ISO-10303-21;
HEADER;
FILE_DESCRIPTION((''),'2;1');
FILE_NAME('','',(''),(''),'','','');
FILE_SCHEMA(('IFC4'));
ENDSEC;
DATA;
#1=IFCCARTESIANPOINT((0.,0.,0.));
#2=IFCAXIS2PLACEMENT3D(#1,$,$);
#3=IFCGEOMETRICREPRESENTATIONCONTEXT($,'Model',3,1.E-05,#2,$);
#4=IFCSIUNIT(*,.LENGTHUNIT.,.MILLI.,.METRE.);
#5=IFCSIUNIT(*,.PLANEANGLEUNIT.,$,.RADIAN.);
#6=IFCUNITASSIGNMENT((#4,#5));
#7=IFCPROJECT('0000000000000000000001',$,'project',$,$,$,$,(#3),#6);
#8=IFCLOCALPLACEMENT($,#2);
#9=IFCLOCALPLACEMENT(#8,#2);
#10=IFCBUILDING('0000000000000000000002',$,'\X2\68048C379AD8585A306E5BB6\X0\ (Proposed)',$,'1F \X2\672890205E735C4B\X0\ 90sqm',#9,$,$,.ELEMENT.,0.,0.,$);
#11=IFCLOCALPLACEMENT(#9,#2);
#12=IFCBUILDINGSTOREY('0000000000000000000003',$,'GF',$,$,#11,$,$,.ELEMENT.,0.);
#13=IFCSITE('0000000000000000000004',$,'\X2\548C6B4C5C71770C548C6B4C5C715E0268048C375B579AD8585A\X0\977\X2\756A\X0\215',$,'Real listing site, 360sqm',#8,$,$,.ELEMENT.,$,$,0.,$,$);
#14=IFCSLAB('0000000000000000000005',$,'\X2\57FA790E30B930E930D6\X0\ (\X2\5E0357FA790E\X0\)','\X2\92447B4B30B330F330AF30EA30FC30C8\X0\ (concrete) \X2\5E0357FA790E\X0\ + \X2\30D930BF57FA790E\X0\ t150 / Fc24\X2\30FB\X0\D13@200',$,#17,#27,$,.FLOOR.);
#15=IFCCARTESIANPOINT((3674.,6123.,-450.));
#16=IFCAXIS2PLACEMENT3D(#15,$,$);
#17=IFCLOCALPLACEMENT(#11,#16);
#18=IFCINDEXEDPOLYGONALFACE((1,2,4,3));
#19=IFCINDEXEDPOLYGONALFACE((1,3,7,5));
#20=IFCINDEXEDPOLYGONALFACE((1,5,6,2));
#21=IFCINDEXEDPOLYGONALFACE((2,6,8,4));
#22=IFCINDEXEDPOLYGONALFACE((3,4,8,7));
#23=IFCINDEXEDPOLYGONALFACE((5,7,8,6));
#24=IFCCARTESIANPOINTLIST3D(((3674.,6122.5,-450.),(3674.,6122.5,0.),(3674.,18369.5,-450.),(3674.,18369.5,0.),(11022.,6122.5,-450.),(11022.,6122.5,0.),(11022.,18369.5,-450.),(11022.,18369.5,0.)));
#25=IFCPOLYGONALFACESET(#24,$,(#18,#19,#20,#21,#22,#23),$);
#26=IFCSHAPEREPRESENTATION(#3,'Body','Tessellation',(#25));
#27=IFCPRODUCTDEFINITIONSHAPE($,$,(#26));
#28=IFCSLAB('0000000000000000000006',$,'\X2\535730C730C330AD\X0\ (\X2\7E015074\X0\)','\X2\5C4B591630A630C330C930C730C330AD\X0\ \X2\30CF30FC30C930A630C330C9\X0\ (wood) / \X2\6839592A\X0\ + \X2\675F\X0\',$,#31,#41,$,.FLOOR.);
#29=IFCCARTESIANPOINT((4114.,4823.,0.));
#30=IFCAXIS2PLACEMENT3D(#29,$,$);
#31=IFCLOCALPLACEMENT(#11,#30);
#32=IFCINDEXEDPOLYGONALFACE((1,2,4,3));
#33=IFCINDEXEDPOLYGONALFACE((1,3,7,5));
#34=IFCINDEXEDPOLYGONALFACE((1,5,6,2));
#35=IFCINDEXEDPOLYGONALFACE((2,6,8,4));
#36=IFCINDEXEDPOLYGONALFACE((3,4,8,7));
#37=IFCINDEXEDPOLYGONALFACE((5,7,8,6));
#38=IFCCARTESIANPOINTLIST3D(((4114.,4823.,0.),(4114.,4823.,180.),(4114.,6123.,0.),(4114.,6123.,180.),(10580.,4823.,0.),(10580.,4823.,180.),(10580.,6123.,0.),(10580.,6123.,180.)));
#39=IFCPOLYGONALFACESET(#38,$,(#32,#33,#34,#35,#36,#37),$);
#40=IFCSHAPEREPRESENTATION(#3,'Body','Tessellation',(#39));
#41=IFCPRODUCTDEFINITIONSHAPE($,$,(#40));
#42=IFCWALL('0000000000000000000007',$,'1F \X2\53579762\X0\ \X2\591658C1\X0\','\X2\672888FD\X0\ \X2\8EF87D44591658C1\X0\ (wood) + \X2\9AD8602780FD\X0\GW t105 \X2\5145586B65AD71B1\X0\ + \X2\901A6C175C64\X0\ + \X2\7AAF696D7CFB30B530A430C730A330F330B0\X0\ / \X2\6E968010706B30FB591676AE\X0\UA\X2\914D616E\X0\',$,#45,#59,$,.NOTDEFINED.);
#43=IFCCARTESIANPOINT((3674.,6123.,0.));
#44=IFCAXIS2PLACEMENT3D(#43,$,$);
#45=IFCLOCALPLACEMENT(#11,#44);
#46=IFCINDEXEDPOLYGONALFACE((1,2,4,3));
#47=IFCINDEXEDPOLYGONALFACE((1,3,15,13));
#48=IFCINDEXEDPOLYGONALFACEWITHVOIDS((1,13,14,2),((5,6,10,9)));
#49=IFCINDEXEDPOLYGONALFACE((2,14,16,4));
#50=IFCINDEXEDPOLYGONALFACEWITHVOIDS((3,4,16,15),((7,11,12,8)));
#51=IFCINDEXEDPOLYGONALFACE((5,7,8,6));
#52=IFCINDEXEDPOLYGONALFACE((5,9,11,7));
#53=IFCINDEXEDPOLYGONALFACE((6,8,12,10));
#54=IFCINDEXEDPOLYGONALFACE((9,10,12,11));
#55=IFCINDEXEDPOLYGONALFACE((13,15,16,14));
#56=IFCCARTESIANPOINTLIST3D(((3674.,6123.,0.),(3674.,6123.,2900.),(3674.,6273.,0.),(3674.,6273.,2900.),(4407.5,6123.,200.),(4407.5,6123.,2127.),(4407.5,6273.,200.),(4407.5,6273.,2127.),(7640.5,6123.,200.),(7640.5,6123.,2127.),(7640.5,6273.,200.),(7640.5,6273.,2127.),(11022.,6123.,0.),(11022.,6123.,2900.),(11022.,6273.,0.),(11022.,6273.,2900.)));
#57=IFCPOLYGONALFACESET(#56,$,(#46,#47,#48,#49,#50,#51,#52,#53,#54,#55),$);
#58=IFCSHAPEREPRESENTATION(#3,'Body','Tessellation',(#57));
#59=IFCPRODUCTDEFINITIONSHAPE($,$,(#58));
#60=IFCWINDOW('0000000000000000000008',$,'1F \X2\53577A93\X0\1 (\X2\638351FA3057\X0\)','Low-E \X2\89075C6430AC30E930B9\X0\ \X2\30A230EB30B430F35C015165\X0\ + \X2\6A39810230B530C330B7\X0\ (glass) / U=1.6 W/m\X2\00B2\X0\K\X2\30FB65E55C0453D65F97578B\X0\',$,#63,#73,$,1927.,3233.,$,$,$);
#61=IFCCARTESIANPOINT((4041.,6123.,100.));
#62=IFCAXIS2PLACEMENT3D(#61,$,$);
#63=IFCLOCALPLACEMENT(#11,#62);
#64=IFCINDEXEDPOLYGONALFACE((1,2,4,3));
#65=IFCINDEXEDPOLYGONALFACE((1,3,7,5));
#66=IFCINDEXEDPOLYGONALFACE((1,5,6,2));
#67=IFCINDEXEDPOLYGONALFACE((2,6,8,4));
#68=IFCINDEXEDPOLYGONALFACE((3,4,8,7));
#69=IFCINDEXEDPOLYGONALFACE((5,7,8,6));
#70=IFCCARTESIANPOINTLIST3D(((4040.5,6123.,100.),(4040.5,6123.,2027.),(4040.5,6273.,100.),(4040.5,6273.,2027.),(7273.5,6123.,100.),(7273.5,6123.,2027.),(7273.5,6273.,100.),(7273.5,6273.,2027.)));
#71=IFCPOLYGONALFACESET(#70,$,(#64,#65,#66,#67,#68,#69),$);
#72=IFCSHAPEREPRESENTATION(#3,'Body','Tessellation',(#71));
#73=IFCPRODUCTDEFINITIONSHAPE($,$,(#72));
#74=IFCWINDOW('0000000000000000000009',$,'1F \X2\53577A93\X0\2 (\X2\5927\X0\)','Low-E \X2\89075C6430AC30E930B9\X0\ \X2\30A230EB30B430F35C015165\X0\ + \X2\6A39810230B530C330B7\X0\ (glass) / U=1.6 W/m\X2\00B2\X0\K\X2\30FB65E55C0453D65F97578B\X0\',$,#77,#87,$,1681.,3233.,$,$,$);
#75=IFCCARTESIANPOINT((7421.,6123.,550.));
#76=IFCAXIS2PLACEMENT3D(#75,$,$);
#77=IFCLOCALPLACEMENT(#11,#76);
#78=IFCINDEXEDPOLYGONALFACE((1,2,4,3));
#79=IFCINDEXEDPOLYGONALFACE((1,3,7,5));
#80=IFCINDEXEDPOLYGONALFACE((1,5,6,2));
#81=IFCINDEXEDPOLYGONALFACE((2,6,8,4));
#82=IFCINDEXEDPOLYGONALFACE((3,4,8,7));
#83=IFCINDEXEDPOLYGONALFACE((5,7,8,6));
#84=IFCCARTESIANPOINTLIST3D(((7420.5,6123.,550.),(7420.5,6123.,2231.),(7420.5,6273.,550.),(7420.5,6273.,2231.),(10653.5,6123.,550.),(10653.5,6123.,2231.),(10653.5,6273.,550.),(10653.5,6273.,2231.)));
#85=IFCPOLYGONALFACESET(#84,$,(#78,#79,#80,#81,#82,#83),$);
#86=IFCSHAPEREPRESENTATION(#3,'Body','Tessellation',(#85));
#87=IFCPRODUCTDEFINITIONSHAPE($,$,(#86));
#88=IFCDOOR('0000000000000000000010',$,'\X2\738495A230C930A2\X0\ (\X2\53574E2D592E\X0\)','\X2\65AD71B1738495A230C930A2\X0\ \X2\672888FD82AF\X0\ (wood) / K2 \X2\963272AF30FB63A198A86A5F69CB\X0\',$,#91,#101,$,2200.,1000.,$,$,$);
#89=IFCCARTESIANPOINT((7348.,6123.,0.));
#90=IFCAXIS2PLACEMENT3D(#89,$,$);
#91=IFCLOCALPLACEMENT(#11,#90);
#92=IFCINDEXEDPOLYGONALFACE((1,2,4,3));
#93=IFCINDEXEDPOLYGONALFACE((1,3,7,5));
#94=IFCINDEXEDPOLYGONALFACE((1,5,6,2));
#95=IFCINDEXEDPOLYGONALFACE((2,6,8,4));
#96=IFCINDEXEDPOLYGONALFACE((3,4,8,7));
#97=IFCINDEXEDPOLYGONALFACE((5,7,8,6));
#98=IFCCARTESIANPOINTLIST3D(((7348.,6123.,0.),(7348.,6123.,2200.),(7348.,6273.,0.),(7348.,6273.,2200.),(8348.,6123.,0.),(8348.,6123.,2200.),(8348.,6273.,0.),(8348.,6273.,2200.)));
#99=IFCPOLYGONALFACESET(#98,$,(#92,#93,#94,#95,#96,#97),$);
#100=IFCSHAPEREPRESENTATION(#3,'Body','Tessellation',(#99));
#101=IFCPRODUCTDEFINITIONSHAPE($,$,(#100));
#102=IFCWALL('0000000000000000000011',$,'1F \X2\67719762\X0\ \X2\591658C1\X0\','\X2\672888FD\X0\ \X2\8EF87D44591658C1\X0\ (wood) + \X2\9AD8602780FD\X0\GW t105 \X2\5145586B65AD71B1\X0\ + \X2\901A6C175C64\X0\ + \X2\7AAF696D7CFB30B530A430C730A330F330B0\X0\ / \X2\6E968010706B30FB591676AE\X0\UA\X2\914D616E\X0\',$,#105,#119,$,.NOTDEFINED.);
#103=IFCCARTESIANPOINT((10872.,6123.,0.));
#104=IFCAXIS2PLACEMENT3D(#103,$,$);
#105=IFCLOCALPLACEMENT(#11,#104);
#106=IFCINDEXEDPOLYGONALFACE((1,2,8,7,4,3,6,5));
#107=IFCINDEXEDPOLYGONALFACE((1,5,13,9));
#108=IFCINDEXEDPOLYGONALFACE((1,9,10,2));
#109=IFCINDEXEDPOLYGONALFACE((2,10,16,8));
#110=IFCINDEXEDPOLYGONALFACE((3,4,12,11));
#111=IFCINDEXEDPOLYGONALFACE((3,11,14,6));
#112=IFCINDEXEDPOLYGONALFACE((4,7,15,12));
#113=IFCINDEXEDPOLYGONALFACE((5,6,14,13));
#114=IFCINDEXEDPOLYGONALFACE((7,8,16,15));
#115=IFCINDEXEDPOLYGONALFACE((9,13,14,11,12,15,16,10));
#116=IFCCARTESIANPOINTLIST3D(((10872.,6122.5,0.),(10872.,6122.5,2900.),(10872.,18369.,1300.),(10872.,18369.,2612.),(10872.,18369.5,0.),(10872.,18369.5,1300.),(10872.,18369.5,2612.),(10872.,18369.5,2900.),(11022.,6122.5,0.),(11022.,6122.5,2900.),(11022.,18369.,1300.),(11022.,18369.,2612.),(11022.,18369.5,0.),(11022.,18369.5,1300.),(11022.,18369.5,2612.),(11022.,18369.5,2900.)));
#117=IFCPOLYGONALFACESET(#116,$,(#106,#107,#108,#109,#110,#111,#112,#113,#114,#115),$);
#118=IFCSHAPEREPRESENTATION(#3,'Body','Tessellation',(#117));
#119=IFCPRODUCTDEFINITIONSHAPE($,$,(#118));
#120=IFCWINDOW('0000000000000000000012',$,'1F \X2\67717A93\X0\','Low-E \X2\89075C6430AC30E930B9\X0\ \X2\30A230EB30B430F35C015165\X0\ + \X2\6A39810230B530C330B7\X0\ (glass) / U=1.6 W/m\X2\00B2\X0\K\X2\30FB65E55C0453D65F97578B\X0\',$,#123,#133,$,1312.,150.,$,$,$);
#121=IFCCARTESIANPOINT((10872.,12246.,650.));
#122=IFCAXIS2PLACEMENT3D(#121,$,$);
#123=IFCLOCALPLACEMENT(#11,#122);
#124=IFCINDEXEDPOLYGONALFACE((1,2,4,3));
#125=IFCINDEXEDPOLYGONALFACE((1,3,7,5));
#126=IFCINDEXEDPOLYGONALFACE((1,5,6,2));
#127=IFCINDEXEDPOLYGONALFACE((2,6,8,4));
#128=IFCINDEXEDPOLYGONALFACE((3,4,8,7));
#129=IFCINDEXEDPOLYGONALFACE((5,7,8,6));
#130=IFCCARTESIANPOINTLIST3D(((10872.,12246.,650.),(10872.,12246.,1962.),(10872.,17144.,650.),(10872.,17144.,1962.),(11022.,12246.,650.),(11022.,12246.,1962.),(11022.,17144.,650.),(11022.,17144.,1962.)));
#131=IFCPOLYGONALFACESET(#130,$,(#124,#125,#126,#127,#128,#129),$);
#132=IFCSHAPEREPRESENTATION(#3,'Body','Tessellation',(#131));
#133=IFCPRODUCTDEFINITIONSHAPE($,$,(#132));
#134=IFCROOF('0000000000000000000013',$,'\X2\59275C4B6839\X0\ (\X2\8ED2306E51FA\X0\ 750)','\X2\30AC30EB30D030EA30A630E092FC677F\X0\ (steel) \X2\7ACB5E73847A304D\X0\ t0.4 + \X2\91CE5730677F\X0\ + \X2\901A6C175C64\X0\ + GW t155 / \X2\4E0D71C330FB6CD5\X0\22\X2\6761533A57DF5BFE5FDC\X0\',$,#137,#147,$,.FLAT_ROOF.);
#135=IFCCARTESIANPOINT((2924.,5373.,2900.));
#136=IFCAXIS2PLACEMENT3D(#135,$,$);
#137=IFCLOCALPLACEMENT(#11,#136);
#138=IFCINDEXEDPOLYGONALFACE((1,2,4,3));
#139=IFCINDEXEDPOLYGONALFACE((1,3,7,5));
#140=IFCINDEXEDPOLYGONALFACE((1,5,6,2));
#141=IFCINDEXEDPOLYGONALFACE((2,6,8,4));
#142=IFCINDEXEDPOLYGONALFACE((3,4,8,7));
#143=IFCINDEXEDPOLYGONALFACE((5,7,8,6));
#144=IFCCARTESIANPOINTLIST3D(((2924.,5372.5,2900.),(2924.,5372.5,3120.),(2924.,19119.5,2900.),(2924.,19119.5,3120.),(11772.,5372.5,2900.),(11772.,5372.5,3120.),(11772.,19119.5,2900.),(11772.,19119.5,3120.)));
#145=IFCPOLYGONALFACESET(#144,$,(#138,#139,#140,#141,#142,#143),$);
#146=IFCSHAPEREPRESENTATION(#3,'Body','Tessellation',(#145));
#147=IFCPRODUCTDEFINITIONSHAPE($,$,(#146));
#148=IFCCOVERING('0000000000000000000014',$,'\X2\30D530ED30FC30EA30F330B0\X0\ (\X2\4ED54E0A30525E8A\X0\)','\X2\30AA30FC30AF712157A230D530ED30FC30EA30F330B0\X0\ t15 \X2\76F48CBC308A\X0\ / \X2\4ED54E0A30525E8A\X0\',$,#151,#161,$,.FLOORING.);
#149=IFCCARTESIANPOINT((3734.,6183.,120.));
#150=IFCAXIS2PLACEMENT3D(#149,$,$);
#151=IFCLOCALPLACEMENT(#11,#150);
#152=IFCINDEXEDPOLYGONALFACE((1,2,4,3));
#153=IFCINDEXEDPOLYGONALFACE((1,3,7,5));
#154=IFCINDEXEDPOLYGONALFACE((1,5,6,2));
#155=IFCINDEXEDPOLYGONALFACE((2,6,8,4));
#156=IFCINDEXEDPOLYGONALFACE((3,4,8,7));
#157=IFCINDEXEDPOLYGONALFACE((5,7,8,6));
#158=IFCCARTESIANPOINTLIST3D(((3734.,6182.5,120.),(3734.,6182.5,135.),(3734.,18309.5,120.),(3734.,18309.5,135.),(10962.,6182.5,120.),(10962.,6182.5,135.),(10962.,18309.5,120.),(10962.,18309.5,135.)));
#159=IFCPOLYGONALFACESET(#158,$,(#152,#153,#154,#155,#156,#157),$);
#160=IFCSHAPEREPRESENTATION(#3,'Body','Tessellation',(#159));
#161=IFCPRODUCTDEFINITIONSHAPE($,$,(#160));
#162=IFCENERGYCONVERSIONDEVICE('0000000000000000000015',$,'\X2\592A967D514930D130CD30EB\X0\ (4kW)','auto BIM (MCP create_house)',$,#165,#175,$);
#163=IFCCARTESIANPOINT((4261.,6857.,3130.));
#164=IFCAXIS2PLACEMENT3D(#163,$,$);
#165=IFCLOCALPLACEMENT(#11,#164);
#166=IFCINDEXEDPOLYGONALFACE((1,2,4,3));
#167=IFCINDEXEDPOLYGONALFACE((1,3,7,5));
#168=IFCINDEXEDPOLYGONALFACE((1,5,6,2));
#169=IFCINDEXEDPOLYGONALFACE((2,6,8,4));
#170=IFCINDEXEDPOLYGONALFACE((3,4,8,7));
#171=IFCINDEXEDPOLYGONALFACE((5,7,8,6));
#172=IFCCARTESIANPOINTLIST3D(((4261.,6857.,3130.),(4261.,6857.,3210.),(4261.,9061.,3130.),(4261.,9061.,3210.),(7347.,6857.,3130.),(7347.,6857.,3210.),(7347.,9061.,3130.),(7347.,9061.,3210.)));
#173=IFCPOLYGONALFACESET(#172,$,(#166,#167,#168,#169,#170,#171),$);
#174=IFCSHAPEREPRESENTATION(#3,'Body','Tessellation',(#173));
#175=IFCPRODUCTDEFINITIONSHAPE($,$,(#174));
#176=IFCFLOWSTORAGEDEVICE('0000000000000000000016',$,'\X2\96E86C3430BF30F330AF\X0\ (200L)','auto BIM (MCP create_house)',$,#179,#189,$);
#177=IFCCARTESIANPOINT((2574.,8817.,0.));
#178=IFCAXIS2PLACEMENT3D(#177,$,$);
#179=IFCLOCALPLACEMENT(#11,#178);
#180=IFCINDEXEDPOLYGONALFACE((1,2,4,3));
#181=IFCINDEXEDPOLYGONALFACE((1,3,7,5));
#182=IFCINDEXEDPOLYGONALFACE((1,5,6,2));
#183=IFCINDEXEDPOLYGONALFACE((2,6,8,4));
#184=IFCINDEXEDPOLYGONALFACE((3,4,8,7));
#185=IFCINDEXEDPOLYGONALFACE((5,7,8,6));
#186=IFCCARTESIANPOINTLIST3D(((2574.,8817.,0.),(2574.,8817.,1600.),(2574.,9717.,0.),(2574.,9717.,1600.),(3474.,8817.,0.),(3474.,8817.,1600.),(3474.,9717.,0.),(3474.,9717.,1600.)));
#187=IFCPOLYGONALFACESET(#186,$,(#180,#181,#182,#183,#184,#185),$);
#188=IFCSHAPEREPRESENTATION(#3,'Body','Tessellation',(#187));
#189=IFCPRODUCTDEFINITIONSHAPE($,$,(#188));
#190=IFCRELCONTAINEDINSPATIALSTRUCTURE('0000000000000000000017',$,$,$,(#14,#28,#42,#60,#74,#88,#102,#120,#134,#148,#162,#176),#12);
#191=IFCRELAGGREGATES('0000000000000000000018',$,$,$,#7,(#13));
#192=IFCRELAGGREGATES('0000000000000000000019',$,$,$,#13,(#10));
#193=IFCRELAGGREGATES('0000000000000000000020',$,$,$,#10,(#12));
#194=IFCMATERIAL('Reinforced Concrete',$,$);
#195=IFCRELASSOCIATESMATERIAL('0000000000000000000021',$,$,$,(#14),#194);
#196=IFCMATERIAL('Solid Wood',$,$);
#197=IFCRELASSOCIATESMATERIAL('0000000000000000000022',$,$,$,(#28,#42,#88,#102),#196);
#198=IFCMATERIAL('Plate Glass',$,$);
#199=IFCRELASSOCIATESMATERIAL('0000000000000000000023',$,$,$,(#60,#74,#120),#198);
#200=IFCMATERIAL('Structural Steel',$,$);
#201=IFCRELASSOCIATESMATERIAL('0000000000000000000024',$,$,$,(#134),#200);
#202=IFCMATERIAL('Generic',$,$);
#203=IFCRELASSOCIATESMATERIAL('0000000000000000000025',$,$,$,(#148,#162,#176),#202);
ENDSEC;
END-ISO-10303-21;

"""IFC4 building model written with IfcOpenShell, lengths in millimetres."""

from ifc_helpers import new_model, si_unit, frame, frame_2d, origin, place, context, project, spatial, rectangle, extrude, material, element, fill, save


model = new_model("IFC4")

# Units and contexts
model_context = context("Model", 3, precision=1e-05, world=origin())
ifc_project = project(units=[si_unit("LENGTHUNIT", "METRE", prefix="MILLI"), si_unit("PLANEANGLEUNIT", "RADIAN")], contexts=[model_context])

# Site, building, storey
site_placement = place(None, origin())
site = spatial("IfcSite", under=ifc_project, at=site_placement, Name="和歌山県和歌山市栄谷字高塚977番215", ObjectType="Real listing site, 360sqm", CompositionType="ELEMENT", RefElevation=0.0)
building_placement = place(site_placement, origin())
building = spatial("IfcBuilding", under=site, at=building_placement, Name="栄谷高塚の家 (Proposed)", ObjectType="1F 木造平屋 90sqm", CompositionType="ELEMENT", ElevationOfRefHeight=0.0, ElevationOfTerrain=0.0)
storey_placement = place(building_placement, origin())
storey = spatial("IfcBuildingStorey", under=building, at=storey_placement, Name="GF", CompositionType="ELEMENT", Elevation=0.0)

# Slabs
ifc_material_1 = material(Name="Reinforced Concrete")
slab_1_placement = place(storey_placement, frame((3674.0, 6123.0, -450.0)))
element("IfcSlab", 1, at=slab_1_placement, inside=storey, material=ifc_material_1, Name="基礎スラブ (布基礎)", Description="鉄筋コンクリート (concrete) 布基礎 + ベタ基礎 t150 / Fc24・D13@200", PredefinedType="FLOOR", context=model_context, shape_type="SweptSolid", body=[
    extrude(rectangle(XDim=7348.0, YDim=12247.0, at=frame_2d((3674.0, 6123.0))), frame((3674.0, 6123.0, -450.0)), (0.0, 0.0, 1.0), 450.0),
])
ifc_material_2 = material(Name="Solid Wood")
slab_2_placement = place(storey_placement, frame((4114.0, 4823.0, 0.0)))
element("IfcSlab", 2, at=slab_2_placement, inside=storey, material=ifc_material_2, Name="南デッキ (縁側)", Description="屋外ウッドデッキ ハードウッド (wood) / 根太 + 束", PredefinedType="FLOOR", context=model_context, shape_type="SweptSolid", body=[
    extrude(rectangle(XDim=6466.0, YDim=1300.0, at=frame_2d((3233.0, 650.0))), frame((4114.0, 4823.0, 0.0)), (0.0, 0.0, 1.0), 180.0),
])

# Wall, openings, windows, door
wall_1_placement = place(storey_placement, frame((3674.0, 6123.0, 0.0)))
wall_1 = element("IfcWall", 3, at=wall_1_placement, inside=storey, material=ifc_material_2, Name="1F 南面 外壁", Description="木製 軸組外壁 (wood) + 高性能GW t105 充填断熱 + 通気層 + 窯業系サイディング / 準耐火・外皮UA配慮", PredefinedType="NOTDEFINED", context=model_context, shape_type="SweptSolid", body=[
    extrude(rectangle(XDim=7348.0, YDim=150.0, at=frame_2d((3674.0, 75.0))), frame((3674.0, 6123.0, 0.0)), (0.0, 0.0, 1.0), 2900.0),
])
opening_1_placement = place(storey_placement, frame((4041.0, 6123.0, 100.0)))
opening_1 = element("IfcOpeningElement", 4, at=opening_1_placement, cuts=wall_1, PredefinedType="NOTDEFINED", context=model_context, shape_type="SweptSolid", body=[
    extrude(rectangle(XDim=3233.0, YDim=150.0, at=frame_2d((1616.0, 75.0))), frame((4041.0, 6123.0, 100.0)), (0.0, 0.0, 1.0), 1927.0),
])
opening_2_placement = place(storey_placement, frame((7421.0, 6123.0, 550.0)))
opening_2 = element("IfcOpeningElement", 5, at=opening_2_placement, cuts=wall_1, PredefinedType="NOTDEFINED", context=model_context, shape_type="SweptSolid", body=[
    extrude(rectangle(XDim=3233.0, YDim=150.0, at=frame_2d((1616.0, 75.0))), frame((7421.0, 6123.0, 550.0)), (0.0, 0.0, 1.0), 1681.0),
])
opening_3_placement = place(storey_placement, frame((7348.0, 6123.0, 0.0)))
opening_3 = element("IfcOpeningElement", 6, at=opening_3_placement, cuts=wall_1, PredefinedType="NOTDEFINED", context=model_context, shape_type="SweptSolid", body=[
    extrude(rectangle(XDim=1000.0, YDim=150.0, at=frame_2d((500.0, 75.0))), frame((7348.0, 6123.0, 0.0)), (0.0, 0.0, 1.0), 2200.0),
])
ifc_material_3 = material(Name="Plate Glass")
window_1_placement = place(storey_placement, frame((4041.0, 6123.0, 100.0)))
window_1 = element("IfcWindow", 7, at=window_1_placement, inside=storey, material=ifc_material_3, Name="1F 南窓1 (掃出し)", Description="Low-E 複層ガラス アルゴン封入 + 樹脂サッシ (glass) / U=1.6 W/m²K・日射取得型", OverallHeight=1927.0, OverallWidth=3233.0, context=model_context, shape_type="SweptSolid", body=[
    extrude(rectangle(XDim=3233.0, YDim=150.0, at=frame_2d((1616.0, 75.0))), frame((4041.0, 6123.0, 100.0)), (0.0, 0.0, 1.0), 1927.0),
])
fill(opening_1, window_1)
window_2_placement = place(storey_placement, frame((7421.0, 6123.0, 550.0)))
window_2 = element("IfcWindow", 8, at=window_2_placement, inside=storey, material=ifc_material_3, Name="1F 南窓2 (大)", Description="Low-E 複層ガラス アルゴン封入 + 樹脂サッシ (glass) / U=1.6 W/m²K・日射取得型", OverallHeight=1681.0, OverallWidth=3233.0, context=model_context, shape_type="SweptSolid", body=[
    extrude(rectangle(XDim=3233.0, YDim=150.0, at=frame_2d((1616.0, 75.0))), frame((7421.0, 6123.0, 550.0)), (0.0, 0.0, 1.0), 1681.0),
])
fill(opening_2, window_2)
door_placement = place(storey_placement, frame((7348.0, 6123.0, 0.0)))
door = element("IfcDoor", 9, at=door_placement, inside=storey, material=ifc_material_2, Name="玄関ドア (南中央)", Description="断熱玄関ドア 木製芯 (wood) / K2 防犯・採風機構", OverallHeight=2200.0, OverallWidth=1000.0, context=model_context, shape_type="SweptSolid", body=[
    extrude(rectangle(XDim=1000.0, YDim=150.0, at=frame_2d((500.0, 75.0))), frame((7348.0, 6123.0, 0.0)), (0.0, 0.0, 1.0), 2200.0),
])
fill(opening_3, door)

# Wall, opening, window
wall_2_placement = place(storey_placement, frame((10872.0, 6123.0, 0.0)))
wall_2 = element("IfcWall", 10, at=wall_2_placement, inside=storey, material=ifc_material_2, Name="1F 東面 外壁", Description="木製 軸組外壁 (wood) + 高性能GW t105 充填断熱 + 通気層 + 窯業系サイディング / 準耐火・外皮UA配慮", PredefinedType="NOTDEFINED", context=model_context, shape_type="SweptSolid", body=[
    extrude(rectangle(XDim=150.0, YDim=12247.0, at=frame_2d((75.0, 6123.0))), frame((10872.0, 6123.0, 0.0)), (0.0, 0.0, 1.0), 2900.0),
])
opening_4_placement = place(storey_placement, frame((10872.0, 12246.0, 650.0)))
opening_4 = element("IfcOpeningElement", 11, at=opening_4_placement, cuts=wall_2, PredefinedType="NOTDEFINED", context=model_context, shape_type="SweptSolid", body=[
    extrude(rectangle(XDim=150.0, YDim=4898.0, at=frame_2d((75.0, 2449.0))), frame((10872.0, 12246.0, 650.0)), (0.0, 0.0, 1.0), 1312.0),
])
window_3_placement = place(storey_placement, frame((10872.0, 12246.0, 650.0)))
window_3 = element("IfcWindow", 12, at=window_3_placement, inside=storey, material=ifc_material_3, Name="1F 東窓", Description="Low-E 複層ガラス アルゴン封入 + 樹脂サッシ (glass) / U=1.6 W/m²K・日射取得型", OverallHeight=1312.0, OverallWidth=150.0, context=model_context, shape_type="SweptSolid", body=[
    extrude(rectangle(XDim=150.0, YDim=4898.0, at=frame_2d((75.0, 2449.0))), frame((10872.0, 12246.0, 650.0)), (0.0, 0.0, 1.0), 1312.0),
])
fill(opening_4, window_3)

# Roof
ifc_material_4 = material(Name="Structural Steel")
roof_placement = place(storey_placement, frame((2924.0, 5373.0, 2900.0)))
element("IfcRoof", 13, at=roof_placement, inside=storey, material=ifc_material_4, Name="大屋根 (軒の出 750)", Description="ガルバリウム鋼板 (steel) 立平葺き t0.4 + 野地板 + 通気層 + GW t155 / 不燃・法22条区域対応", PredefinedType="FLAT_ROOF", context=model_context, shape_type="SweptSolid", body=[
    extrude(rectangle(XDim=8848.0, YDim=13747.0, at=frame_2d((4424.0, 6873.0))), frame((2924.0, 5373.0, 2900.0)), (0.0, 0.0, 1.0), 220.0),
])

# Covering
ifc_material_5 = material(Name="Generic")
covering_placement = place(storey_placement, frame((3734.0, 6183.0, 120.0)))
element("IfcCovering", 14, at=covering_placement, inside=storey, material=ifc_material_5, Name="フローリング (仕上げ床)", Description="オーク無垢フローリング t15 直貼り / 仕上げ床", PredefinedType="FLOORING", context=model_context, shape_type="SweptSolid", body=[
    extrude(rectangle(XDim=7228.0, YDim=12127.0, at=frame_2d((3614.0, 6063.0))), frame((3734.0, 6183.0, 120.0)), (0.0, 0.0, 1.0), 15.0),
])

# Energy conversion device
energy_conversion_device_placement = place(storey_placement, frame((4261.0, 6857.0, 3130.0)))
element("IfcEnergyConversionDevice", 15, at=energy_conversion_device_placement, inside=storey, material=ifc_material_5, Name="太陽光パネル (4kW)", Description="auto BIM (MCP create_house)", context=model_context, shape_type="SweptSolid", body=[
    extrude(rectangle(XDim=3086.0, YDim=2204.0, at=frame_2d((1543.0, 1102.0))), frame((4261.0, 6857.0, 3130.0)), (0.0, 0.0, 1.0), 80.0),
])

# Flow storage device
flow_storage_device_placement = place(storey_placement, frame((2574.0, 8817.0, 0.0)))
element("IfcFlowStorageDevice", 16, at=flow_storage_device_placement, inside=storey, material=ifc_material_5, Name="雨水タンク (200L)", Description="auto BIM (MCP create_house)", context=model_context, shape_type="SweptSolid", body=[
    extrude(rectangle(XDim=900.0, YDim=900.0, at=frame_2d((450.0, 450.0))), frame((2574.0, 8817.0, 0.0)), (0.0, 0.0, 1.0), 1600.0),
])

save(model, "model.ifc")
